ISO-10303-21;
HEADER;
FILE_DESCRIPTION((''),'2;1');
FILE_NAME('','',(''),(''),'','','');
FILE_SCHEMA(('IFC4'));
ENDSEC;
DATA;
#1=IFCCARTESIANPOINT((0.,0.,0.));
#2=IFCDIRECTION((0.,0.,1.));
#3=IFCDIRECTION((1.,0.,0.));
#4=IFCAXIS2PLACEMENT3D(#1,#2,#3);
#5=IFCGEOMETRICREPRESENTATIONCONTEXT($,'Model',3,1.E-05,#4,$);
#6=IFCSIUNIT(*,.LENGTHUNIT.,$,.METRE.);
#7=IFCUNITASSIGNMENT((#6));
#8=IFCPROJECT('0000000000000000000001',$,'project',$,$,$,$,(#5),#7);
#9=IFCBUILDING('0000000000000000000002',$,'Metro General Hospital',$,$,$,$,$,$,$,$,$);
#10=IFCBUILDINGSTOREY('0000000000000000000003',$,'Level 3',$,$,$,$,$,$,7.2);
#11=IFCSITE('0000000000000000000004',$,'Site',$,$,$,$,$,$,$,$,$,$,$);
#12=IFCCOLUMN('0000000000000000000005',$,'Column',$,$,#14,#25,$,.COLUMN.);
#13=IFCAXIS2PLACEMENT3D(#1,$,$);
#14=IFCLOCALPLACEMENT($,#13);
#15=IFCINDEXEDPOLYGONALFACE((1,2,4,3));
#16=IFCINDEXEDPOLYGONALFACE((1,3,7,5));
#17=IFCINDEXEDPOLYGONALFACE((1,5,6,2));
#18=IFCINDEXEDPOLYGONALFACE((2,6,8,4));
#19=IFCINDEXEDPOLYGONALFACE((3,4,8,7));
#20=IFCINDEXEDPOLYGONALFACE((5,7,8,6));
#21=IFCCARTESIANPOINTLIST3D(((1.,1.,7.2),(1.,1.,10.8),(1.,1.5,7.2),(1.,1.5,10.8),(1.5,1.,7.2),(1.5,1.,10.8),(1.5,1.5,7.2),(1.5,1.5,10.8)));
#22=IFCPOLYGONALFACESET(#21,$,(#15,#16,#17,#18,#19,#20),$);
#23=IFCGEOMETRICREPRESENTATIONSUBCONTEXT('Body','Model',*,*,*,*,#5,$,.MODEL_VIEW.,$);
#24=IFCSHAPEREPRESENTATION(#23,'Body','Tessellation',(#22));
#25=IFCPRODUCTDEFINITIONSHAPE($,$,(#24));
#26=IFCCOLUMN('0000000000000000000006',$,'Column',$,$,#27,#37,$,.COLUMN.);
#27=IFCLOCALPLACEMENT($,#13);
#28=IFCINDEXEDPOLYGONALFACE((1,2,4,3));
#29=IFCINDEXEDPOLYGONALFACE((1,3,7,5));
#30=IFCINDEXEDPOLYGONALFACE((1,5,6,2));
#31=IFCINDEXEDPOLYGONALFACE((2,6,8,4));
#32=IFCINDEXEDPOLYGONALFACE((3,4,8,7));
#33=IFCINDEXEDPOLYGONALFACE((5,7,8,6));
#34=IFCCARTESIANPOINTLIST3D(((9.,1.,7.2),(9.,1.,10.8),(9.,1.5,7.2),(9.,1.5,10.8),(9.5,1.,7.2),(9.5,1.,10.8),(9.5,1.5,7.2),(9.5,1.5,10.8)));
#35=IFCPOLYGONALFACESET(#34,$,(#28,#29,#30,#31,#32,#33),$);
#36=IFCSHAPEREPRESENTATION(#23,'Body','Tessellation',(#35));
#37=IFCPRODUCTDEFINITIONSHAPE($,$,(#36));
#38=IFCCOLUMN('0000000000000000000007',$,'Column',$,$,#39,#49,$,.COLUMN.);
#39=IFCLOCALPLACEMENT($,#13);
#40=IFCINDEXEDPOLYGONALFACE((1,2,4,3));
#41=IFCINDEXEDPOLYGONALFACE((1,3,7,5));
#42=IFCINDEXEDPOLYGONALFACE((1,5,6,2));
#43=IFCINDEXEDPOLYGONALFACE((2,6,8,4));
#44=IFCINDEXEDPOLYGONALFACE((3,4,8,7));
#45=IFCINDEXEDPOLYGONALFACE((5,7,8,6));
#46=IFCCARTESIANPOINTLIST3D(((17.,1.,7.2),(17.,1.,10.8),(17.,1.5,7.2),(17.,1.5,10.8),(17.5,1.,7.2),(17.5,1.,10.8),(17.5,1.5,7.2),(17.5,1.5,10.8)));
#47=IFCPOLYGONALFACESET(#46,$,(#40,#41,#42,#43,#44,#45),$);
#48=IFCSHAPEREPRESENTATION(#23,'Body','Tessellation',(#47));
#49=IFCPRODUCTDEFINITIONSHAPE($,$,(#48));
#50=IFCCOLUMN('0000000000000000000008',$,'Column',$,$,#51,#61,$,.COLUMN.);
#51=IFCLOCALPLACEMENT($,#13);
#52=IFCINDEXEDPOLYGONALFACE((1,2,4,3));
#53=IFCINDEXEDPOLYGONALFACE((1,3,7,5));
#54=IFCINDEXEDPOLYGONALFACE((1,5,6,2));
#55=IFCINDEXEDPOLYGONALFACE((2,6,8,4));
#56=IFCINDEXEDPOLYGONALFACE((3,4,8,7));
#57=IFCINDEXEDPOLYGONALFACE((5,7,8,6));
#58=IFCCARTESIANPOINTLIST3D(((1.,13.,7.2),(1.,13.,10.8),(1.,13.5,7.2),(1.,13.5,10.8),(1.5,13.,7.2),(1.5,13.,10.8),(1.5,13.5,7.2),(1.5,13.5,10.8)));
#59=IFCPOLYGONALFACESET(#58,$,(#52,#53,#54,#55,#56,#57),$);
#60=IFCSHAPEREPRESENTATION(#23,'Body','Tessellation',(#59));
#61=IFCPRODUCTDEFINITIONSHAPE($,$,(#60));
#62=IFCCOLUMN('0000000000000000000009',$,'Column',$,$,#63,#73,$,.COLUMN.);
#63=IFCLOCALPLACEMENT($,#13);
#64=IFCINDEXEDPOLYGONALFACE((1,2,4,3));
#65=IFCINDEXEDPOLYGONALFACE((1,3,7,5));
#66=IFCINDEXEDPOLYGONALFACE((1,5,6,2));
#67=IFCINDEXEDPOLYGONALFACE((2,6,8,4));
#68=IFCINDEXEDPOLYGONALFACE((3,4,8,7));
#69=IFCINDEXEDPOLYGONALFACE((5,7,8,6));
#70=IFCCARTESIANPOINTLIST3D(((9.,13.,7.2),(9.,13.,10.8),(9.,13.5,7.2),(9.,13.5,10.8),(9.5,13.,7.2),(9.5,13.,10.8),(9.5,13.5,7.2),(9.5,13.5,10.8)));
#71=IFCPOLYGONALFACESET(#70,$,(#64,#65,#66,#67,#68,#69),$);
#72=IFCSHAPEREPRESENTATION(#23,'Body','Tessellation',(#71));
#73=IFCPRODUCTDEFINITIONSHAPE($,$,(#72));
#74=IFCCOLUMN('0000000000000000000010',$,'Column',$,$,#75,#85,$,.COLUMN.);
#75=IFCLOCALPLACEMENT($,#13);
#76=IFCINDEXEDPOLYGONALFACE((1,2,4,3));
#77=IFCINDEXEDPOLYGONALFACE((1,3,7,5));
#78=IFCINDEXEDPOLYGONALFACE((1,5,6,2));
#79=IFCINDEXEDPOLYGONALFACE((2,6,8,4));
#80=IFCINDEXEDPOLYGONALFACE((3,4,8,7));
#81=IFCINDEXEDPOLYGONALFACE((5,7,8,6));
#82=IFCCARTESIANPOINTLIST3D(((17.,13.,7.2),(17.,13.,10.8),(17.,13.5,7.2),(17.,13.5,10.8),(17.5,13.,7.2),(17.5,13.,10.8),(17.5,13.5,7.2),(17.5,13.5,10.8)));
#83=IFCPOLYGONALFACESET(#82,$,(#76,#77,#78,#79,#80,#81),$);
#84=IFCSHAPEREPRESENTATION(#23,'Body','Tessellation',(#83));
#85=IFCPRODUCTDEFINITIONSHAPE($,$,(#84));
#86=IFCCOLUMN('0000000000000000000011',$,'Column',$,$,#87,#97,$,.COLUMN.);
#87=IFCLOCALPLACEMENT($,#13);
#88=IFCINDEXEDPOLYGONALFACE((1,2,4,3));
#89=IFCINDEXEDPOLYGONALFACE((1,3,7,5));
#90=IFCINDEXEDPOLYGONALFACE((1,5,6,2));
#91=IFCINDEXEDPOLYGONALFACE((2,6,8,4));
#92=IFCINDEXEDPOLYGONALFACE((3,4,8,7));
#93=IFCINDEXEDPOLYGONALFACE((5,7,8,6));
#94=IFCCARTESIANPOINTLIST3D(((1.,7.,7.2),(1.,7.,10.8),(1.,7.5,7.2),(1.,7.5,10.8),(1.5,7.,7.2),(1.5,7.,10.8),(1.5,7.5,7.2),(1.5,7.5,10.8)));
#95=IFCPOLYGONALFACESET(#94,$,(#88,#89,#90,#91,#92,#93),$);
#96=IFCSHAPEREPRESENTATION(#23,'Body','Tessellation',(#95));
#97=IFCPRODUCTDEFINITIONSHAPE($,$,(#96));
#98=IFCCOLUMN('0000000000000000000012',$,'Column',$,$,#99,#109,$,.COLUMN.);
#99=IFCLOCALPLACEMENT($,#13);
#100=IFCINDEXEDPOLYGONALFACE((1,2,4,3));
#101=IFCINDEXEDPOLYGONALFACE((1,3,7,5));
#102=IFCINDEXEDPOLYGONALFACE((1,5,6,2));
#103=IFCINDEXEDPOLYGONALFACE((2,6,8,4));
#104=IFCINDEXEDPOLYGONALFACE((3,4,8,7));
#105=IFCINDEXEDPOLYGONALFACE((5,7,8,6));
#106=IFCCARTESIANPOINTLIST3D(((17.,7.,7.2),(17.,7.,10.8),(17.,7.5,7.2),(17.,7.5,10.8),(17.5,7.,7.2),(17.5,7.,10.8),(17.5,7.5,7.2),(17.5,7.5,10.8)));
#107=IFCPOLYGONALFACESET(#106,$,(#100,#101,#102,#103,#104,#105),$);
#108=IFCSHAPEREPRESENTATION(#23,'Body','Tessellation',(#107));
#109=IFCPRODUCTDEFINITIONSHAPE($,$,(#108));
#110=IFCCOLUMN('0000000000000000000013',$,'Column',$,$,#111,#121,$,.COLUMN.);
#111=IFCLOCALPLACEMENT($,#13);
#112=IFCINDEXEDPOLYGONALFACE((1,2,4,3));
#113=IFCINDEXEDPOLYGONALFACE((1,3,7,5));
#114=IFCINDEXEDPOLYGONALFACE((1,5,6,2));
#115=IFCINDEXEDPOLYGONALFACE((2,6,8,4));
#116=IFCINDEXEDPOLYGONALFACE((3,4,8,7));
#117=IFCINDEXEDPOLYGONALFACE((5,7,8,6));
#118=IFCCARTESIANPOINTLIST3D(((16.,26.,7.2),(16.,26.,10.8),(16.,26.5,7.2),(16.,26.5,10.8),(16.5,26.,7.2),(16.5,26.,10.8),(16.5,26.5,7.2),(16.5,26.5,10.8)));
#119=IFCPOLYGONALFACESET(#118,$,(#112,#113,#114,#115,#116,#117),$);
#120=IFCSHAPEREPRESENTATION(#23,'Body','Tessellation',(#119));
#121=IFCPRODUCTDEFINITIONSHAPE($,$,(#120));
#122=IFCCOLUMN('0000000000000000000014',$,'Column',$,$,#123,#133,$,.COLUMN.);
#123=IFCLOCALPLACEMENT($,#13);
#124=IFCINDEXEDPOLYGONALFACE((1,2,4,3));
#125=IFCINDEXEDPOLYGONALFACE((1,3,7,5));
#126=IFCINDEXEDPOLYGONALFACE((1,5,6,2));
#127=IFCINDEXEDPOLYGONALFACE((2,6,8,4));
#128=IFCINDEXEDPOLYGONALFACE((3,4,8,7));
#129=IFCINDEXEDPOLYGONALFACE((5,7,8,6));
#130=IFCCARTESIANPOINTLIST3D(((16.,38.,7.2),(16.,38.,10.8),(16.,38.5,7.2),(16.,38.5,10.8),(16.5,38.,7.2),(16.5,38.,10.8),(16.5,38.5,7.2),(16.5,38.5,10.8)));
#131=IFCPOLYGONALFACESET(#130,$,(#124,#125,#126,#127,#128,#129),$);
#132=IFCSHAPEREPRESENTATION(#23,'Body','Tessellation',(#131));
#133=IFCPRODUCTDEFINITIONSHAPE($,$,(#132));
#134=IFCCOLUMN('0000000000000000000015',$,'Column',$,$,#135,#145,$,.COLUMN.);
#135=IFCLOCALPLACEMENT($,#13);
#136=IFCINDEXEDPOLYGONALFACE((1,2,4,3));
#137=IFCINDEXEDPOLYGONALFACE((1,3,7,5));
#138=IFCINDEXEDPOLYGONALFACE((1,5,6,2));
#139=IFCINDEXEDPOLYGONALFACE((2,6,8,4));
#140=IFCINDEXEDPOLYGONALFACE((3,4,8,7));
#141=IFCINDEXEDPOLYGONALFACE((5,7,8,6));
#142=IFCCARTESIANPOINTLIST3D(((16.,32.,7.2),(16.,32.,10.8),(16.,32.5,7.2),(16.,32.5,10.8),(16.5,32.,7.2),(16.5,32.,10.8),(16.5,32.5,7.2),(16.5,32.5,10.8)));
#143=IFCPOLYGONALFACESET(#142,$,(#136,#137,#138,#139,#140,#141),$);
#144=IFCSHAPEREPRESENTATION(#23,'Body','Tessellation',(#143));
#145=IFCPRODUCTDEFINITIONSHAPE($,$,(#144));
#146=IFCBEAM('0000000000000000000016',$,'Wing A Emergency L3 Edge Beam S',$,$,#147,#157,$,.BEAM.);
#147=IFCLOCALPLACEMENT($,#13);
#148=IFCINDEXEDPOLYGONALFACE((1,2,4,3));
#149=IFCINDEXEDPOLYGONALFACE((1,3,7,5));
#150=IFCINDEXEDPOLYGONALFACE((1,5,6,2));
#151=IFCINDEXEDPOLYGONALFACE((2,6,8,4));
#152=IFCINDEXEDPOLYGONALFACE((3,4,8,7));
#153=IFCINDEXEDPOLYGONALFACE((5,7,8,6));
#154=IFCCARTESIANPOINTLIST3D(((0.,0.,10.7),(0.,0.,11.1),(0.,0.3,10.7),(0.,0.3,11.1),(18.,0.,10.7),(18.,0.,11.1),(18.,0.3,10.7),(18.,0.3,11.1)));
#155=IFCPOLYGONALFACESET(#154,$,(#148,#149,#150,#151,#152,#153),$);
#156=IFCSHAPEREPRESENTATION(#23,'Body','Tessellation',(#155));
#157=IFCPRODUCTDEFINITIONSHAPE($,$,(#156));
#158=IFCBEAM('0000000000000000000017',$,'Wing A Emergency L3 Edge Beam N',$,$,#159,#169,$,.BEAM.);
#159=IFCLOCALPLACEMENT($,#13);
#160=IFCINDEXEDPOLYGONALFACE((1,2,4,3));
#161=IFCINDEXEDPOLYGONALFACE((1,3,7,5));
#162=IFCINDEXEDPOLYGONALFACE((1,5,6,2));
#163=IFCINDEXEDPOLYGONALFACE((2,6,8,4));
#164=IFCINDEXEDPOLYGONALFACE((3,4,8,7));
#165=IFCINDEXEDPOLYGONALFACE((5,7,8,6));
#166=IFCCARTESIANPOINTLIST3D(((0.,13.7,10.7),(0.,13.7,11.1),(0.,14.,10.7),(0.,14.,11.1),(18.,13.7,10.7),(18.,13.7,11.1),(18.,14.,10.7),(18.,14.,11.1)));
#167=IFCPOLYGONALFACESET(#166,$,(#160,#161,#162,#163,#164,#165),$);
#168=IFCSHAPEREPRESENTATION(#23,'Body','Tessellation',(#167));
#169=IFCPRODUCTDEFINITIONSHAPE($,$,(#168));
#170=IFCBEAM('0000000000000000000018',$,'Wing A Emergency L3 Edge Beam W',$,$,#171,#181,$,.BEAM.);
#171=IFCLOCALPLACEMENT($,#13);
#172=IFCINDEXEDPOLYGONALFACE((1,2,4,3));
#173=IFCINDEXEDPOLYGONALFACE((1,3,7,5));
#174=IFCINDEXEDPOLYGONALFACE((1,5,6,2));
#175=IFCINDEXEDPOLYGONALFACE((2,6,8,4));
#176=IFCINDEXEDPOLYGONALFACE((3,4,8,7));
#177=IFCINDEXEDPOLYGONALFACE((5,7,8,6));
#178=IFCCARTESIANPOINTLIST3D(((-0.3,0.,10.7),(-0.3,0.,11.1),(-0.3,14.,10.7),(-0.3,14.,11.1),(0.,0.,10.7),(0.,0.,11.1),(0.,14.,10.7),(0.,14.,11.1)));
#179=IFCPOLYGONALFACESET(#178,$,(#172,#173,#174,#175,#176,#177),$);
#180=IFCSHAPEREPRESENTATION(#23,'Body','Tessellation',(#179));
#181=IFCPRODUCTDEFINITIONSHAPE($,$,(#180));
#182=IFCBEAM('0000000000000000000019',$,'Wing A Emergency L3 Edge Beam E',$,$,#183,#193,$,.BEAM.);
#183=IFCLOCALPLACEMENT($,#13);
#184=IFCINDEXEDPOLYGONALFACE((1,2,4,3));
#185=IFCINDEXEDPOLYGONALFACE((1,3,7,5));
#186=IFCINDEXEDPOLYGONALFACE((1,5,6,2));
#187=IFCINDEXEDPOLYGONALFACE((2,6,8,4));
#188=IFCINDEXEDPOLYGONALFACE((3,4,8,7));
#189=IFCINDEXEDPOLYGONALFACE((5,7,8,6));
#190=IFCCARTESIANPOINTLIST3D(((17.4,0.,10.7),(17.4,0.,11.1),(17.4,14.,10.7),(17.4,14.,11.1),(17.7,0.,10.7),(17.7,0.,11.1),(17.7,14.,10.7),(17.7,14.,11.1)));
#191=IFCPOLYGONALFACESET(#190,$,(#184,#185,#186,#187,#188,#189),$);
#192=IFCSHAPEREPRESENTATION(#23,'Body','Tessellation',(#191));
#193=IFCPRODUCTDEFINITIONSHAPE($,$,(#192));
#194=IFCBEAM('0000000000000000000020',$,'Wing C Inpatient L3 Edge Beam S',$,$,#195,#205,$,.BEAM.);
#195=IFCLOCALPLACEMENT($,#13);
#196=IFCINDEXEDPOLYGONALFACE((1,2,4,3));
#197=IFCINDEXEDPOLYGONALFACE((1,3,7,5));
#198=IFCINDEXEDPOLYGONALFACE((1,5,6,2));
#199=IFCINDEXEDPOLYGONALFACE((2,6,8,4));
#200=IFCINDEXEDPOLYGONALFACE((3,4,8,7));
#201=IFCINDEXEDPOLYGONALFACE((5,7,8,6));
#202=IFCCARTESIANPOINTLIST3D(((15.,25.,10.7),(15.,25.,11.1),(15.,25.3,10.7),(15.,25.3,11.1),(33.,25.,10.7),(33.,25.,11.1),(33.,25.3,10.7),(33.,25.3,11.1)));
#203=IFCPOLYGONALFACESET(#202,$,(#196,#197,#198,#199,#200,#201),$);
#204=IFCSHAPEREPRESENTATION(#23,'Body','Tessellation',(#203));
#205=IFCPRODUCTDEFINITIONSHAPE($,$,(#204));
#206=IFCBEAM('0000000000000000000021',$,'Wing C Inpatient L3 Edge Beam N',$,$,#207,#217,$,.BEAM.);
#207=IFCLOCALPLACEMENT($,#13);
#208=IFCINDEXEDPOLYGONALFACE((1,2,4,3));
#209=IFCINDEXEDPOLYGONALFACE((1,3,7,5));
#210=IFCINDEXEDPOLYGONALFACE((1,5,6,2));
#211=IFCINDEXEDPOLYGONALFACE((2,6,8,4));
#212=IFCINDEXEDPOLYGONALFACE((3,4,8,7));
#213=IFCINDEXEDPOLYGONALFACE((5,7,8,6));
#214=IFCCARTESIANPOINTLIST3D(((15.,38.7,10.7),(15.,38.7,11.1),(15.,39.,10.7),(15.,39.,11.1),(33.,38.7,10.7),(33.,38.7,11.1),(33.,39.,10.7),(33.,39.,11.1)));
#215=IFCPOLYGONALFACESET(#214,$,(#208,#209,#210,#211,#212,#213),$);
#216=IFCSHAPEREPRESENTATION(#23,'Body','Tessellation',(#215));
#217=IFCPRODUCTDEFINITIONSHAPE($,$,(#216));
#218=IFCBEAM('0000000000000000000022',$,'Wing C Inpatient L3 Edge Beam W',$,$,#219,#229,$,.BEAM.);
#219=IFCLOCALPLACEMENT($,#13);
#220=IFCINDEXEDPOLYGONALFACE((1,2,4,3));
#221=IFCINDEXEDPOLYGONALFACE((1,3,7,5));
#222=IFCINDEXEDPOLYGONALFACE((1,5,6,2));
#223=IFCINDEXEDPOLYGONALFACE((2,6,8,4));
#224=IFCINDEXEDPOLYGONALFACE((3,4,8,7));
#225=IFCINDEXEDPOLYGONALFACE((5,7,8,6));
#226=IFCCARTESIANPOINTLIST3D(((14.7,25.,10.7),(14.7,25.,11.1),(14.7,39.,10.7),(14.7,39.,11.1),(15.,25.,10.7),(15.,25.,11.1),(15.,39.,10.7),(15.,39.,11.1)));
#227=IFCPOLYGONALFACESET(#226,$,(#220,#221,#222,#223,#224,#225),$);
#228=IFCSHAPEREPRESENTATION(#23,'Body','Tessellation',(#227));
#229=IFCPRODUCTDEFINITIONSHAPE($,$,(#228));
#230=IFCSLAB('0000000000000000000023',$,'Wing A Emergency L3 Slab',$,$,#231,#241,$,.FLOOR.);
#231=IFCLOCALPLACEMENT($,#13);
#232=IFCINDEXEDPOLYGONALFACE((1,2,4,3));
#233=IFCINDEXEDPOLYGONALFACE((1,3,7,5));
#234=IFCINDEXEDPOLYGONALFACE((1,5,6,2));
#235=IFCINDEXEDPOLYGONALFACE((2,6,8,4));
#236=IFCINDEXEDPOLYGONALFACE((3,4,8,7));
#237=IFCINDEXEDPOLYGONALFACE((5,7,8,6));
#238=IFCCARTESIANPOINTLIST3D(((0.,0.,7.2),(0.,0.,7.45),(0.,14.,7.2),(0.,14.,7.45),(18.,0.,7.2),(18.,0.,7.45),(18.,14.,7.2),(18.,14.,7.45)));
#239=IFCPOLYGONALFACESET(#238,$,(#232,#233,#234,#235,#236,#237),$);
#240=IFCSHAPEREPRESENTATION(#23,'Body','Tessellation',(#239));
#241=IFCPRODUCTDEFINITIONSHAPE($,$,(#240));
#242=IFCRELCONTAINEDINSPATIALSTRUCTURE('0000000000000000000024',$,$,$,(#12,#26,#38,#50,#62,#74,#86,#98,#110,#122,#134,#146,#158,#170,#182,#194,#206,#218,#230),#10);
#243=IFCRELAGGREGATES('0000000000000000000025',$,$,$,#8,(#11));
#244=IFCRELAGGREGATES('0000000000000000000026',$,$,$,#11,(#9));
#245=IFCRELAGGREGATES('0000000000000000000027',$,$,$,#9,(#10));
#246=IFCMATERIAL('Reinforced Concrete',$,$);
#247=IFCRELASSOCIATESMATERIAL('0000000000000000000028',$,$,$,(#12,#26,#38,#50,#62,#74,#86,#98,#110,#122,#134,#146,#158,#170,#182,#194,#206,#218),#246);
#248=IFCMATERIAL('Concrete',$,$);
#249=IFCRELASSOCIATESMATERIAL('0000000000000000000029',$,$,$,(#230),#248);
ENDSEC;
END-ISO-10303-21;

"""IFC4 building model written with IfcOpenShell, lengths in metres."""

from ifc_helpers import new_model, si_unit, frame, origin_with_axes, place, context, subcontext, project, spatial, line, indexed_curve, outline, extrude, material, element, save


model = new_model("IFC4")

# Units and contexts
model_context = context("Model", 3, precision=1e-05, world=origin_with_axes())
body_context = subcontext(model_context, "Body", "Model", "MODEL_VIEW")
ifc_project = project(units=[si_unit("LENGTHUNIT", "METRE")], contexts=[model_context])

# Site, building, storey
site = spatial("IfcSite", under=ifc_project, Name="Site")
building = spatial("IfcBuilding", under=site, Name="Metro General Hospital")
storey = spatial("IfcBuildingStorey", under=building, Name="Level 3", Elevation=7.2)

# Columns
ifc_material_1 = material(Name="Reinforced Concrete")
for number, where, z_axis, x_axis, name in (
    (1, (1.0, 1.0, 7.2), (0.0, 0.0, 1.0), (1.0, 0.0, 0.0), "Column"),
    (2, (9.0, 1.0, 7.2), (0.0, 0.0, 1.0), (1.0, 0.0, 0.0), "Column"),
    (3, (17.0, 1.0, 7.2), (0.0, 0.0, 1.0), (1.0, 0.0, 0.0), "Column"),
    (4, (1.0, 13.0, 7.2), (0.0, 0.0, 1.0), (1.0, 0.0, 0.0), "Column"),
    (5, (9.0, 13.0, 7.2), (0.0, 0.0, 1.0), (1.0, 0.0, 0.0), "Column"),
    (6, (17.0, 13.0, 7.2), (0.0, 0.0, 1.0), (1.0, 0.0, 0.0), "Column"),
    (7, (1.0, 7.0, 7.2), (0.0, 0.0, 1.0), (1.0, 0.0, 0.0), "Column"),
    (8, (17.0, 7.0, 7.2), (0.0, 0.0, 1.0), (1.0, 0.0, 0.0), "Column"),
    (9, (16.0, 26.0, 7.2), (0.0, 0.0, 1.0), (1.0, 0.0, 0.0), "Column"),
    (10, (16.0, 38.0, 7.2), (0.0, 0.0, 1.0), (1.0, 0.0, 0.0), "Column"),
    (11, (16.0, 32.0, 7.2), (0.0, 0.0, 1.0), (1.0, 0.0, 0.0), "Column"),
):
    element("IfcColumn", number, at=place(None, frame(where, z_axis=z_axis, x_axis=x_axis)), inside=storey, material=ifc_material_1, Name=name, PredefinedType="COLUMN", context=body_context, shape_type="SweptSolid", body=[
        extrude(outline(indexed_curve([(0.0, 0.0), (0.5, 0.0), (0.5, 0.5), (0.0, 0.5)], segments=[line(1, 2, 3, 4, 1)])), origin_with_axes(), (0.0, 0.0, 1.0), 3.6),
    ])

# Beams
for number, where, z_axis, x_axis, name in (
    (12, (0.0, 0.0, 10.7), (0.0, 0.0, 1.0), (1.0, 0.0, 0.0), "Wing A Emergency L3 Edge Beam S"),
    (13, (0.0, 13.7, 10.7), (0.0, 0.0, 1.0), (1.0, 0.0, 0.0), "Wing A Emergency L3 Edge Beam N"),
):
    element("IfcBeam", number, at=place(None, frame(where, z_axis=z_axis, x_axis=x_axis)), inside=storey, material=ifc_material_1, Name=name, PredefinedType="BEAM", context=body_context, shape_type="SweptSolid", body=[
        extrude(outline(indexed_curve([(0.0, 0.0), (18.0, 0.0), (18.0, 0.3), (0.0, 0.3)], segments=[line(1, 2, 3, 4, 1)])), origin_with_axes(), (0.0, 0.0, 1.0), 0.4),
    ])
for number, where, z_axis, x_axis, name in (
    (14, (0.0, 0.0, 10.7), (0.0, 0.0, 1.0), (0.0, 1.0, 0.0), "Wing A Emergency L3 Edge Beam W"),
    (15, (17.7, 0.0, 10.7), (0.0, 0.0, 1.0), (0.0, 1.0, 0.0), "Wing A Emergency L3 Edge Beam E"),
):
    element("IfcBeam", number, at=place(None, frame(where, z_axis=z_axis, x_axis=x_axis)), inside=storey, material=ifc_material_1, Name=name, PredefinedType="BEAM", context=body_context, shape_type="SweptSolid", body=[
        extrude(outline(indexed_curve([(0.0, 0.0), (14.0, 0.0), (14.0, 0.3), (0.0, 0.3)], segments=[line(1, 2, 3, 4, 1)])), origin_with_axes(), (0.0, 0.0, 1.0), 0.4),
    ])
for number, where, z_axis, x_axis, name in (
    (16, (15.0, 25.0, 10.7), (0.0, 0.0, 1.0), (1.0, 0.0, 0.0), "Wing C Inpatient L3 Edge Beam S"),
    (17, (15.0, 38.7, 10.7), (0.0, 0.0, 1.0), (1.0, 0.0, 0.0), "Wing C Inpatient L3 Edge Beam N"),
):
    element("IfcBeam", number, at=place(None, frame(where, z_axis=z_axis, x_axis=x_axis)), inside=storey, material=ifc_material_1, Name=name, PredefinedType="BEAM", context=body_context, shape_type="SweptSolid", body=[
        extrude(outline(indexed_curve([(0.0, 0.0), (18.0, 0.0), (18.0, 0.3), (0.0, 0.3)], segments=[line(1, 2, 3, 4, 1)])), origin_with_axes(), (0.0, 0.0, 1.0), 0.4),
    ])
beam_placement = place(None, frame((15.0, 25.0, 10.7), z_axis=(0.0, 0.0, 1.0), x_axis=(0.0, 1.0, 0.0)))
element("IfcBeam", 18, at=beam_placement, inside=storey, material=ifc_material_1, Name="Wing C Inpatient L3 Edge Beam W", PredefinedType="BEAM", context=body_context, shape_type="SweptSolid", body=[
    extrude(outline(indexed_curve([(0.0, 0.0), (14.0, 0.0), (14.0, 0.3), (0.0, 0.3)], segments=[line(1, 2, 3, 4, 1)])), origin_with_axes(), (0.0, 0.0, 1.0), 0.4),
])

# Slab
ifc_material_2 = material(Name="Concrete")
for number, where, z_axis, x_axis, name in (
    (19, (0.0, 0.0, 7.2), (0.0, 0.0, 1.0), (1.0, 0.0, 0.0), "Wing A Emergency L3 Slab"),
):
    element("IfcSlab", number, at=place(None, frame(where, z_axis=z_axis, x_axis=x_axis)), inside=storey, material=ifc_material_2, Name=name, PredefinedType="FLOOR", context=body_context, shape_type="SweptSolid", body=[
        extrude(outline(indexed_curve([(0.0, 0.0), (18.0, 0.0), (18.0, 14.0), (0.0, 14.0)], segments=[line(1, 2, 3, 4, 1)])), origin_with_axes(), (0.0, 0.0, 1.0), 0.25),
    ])

save(model, "model.ifc")
